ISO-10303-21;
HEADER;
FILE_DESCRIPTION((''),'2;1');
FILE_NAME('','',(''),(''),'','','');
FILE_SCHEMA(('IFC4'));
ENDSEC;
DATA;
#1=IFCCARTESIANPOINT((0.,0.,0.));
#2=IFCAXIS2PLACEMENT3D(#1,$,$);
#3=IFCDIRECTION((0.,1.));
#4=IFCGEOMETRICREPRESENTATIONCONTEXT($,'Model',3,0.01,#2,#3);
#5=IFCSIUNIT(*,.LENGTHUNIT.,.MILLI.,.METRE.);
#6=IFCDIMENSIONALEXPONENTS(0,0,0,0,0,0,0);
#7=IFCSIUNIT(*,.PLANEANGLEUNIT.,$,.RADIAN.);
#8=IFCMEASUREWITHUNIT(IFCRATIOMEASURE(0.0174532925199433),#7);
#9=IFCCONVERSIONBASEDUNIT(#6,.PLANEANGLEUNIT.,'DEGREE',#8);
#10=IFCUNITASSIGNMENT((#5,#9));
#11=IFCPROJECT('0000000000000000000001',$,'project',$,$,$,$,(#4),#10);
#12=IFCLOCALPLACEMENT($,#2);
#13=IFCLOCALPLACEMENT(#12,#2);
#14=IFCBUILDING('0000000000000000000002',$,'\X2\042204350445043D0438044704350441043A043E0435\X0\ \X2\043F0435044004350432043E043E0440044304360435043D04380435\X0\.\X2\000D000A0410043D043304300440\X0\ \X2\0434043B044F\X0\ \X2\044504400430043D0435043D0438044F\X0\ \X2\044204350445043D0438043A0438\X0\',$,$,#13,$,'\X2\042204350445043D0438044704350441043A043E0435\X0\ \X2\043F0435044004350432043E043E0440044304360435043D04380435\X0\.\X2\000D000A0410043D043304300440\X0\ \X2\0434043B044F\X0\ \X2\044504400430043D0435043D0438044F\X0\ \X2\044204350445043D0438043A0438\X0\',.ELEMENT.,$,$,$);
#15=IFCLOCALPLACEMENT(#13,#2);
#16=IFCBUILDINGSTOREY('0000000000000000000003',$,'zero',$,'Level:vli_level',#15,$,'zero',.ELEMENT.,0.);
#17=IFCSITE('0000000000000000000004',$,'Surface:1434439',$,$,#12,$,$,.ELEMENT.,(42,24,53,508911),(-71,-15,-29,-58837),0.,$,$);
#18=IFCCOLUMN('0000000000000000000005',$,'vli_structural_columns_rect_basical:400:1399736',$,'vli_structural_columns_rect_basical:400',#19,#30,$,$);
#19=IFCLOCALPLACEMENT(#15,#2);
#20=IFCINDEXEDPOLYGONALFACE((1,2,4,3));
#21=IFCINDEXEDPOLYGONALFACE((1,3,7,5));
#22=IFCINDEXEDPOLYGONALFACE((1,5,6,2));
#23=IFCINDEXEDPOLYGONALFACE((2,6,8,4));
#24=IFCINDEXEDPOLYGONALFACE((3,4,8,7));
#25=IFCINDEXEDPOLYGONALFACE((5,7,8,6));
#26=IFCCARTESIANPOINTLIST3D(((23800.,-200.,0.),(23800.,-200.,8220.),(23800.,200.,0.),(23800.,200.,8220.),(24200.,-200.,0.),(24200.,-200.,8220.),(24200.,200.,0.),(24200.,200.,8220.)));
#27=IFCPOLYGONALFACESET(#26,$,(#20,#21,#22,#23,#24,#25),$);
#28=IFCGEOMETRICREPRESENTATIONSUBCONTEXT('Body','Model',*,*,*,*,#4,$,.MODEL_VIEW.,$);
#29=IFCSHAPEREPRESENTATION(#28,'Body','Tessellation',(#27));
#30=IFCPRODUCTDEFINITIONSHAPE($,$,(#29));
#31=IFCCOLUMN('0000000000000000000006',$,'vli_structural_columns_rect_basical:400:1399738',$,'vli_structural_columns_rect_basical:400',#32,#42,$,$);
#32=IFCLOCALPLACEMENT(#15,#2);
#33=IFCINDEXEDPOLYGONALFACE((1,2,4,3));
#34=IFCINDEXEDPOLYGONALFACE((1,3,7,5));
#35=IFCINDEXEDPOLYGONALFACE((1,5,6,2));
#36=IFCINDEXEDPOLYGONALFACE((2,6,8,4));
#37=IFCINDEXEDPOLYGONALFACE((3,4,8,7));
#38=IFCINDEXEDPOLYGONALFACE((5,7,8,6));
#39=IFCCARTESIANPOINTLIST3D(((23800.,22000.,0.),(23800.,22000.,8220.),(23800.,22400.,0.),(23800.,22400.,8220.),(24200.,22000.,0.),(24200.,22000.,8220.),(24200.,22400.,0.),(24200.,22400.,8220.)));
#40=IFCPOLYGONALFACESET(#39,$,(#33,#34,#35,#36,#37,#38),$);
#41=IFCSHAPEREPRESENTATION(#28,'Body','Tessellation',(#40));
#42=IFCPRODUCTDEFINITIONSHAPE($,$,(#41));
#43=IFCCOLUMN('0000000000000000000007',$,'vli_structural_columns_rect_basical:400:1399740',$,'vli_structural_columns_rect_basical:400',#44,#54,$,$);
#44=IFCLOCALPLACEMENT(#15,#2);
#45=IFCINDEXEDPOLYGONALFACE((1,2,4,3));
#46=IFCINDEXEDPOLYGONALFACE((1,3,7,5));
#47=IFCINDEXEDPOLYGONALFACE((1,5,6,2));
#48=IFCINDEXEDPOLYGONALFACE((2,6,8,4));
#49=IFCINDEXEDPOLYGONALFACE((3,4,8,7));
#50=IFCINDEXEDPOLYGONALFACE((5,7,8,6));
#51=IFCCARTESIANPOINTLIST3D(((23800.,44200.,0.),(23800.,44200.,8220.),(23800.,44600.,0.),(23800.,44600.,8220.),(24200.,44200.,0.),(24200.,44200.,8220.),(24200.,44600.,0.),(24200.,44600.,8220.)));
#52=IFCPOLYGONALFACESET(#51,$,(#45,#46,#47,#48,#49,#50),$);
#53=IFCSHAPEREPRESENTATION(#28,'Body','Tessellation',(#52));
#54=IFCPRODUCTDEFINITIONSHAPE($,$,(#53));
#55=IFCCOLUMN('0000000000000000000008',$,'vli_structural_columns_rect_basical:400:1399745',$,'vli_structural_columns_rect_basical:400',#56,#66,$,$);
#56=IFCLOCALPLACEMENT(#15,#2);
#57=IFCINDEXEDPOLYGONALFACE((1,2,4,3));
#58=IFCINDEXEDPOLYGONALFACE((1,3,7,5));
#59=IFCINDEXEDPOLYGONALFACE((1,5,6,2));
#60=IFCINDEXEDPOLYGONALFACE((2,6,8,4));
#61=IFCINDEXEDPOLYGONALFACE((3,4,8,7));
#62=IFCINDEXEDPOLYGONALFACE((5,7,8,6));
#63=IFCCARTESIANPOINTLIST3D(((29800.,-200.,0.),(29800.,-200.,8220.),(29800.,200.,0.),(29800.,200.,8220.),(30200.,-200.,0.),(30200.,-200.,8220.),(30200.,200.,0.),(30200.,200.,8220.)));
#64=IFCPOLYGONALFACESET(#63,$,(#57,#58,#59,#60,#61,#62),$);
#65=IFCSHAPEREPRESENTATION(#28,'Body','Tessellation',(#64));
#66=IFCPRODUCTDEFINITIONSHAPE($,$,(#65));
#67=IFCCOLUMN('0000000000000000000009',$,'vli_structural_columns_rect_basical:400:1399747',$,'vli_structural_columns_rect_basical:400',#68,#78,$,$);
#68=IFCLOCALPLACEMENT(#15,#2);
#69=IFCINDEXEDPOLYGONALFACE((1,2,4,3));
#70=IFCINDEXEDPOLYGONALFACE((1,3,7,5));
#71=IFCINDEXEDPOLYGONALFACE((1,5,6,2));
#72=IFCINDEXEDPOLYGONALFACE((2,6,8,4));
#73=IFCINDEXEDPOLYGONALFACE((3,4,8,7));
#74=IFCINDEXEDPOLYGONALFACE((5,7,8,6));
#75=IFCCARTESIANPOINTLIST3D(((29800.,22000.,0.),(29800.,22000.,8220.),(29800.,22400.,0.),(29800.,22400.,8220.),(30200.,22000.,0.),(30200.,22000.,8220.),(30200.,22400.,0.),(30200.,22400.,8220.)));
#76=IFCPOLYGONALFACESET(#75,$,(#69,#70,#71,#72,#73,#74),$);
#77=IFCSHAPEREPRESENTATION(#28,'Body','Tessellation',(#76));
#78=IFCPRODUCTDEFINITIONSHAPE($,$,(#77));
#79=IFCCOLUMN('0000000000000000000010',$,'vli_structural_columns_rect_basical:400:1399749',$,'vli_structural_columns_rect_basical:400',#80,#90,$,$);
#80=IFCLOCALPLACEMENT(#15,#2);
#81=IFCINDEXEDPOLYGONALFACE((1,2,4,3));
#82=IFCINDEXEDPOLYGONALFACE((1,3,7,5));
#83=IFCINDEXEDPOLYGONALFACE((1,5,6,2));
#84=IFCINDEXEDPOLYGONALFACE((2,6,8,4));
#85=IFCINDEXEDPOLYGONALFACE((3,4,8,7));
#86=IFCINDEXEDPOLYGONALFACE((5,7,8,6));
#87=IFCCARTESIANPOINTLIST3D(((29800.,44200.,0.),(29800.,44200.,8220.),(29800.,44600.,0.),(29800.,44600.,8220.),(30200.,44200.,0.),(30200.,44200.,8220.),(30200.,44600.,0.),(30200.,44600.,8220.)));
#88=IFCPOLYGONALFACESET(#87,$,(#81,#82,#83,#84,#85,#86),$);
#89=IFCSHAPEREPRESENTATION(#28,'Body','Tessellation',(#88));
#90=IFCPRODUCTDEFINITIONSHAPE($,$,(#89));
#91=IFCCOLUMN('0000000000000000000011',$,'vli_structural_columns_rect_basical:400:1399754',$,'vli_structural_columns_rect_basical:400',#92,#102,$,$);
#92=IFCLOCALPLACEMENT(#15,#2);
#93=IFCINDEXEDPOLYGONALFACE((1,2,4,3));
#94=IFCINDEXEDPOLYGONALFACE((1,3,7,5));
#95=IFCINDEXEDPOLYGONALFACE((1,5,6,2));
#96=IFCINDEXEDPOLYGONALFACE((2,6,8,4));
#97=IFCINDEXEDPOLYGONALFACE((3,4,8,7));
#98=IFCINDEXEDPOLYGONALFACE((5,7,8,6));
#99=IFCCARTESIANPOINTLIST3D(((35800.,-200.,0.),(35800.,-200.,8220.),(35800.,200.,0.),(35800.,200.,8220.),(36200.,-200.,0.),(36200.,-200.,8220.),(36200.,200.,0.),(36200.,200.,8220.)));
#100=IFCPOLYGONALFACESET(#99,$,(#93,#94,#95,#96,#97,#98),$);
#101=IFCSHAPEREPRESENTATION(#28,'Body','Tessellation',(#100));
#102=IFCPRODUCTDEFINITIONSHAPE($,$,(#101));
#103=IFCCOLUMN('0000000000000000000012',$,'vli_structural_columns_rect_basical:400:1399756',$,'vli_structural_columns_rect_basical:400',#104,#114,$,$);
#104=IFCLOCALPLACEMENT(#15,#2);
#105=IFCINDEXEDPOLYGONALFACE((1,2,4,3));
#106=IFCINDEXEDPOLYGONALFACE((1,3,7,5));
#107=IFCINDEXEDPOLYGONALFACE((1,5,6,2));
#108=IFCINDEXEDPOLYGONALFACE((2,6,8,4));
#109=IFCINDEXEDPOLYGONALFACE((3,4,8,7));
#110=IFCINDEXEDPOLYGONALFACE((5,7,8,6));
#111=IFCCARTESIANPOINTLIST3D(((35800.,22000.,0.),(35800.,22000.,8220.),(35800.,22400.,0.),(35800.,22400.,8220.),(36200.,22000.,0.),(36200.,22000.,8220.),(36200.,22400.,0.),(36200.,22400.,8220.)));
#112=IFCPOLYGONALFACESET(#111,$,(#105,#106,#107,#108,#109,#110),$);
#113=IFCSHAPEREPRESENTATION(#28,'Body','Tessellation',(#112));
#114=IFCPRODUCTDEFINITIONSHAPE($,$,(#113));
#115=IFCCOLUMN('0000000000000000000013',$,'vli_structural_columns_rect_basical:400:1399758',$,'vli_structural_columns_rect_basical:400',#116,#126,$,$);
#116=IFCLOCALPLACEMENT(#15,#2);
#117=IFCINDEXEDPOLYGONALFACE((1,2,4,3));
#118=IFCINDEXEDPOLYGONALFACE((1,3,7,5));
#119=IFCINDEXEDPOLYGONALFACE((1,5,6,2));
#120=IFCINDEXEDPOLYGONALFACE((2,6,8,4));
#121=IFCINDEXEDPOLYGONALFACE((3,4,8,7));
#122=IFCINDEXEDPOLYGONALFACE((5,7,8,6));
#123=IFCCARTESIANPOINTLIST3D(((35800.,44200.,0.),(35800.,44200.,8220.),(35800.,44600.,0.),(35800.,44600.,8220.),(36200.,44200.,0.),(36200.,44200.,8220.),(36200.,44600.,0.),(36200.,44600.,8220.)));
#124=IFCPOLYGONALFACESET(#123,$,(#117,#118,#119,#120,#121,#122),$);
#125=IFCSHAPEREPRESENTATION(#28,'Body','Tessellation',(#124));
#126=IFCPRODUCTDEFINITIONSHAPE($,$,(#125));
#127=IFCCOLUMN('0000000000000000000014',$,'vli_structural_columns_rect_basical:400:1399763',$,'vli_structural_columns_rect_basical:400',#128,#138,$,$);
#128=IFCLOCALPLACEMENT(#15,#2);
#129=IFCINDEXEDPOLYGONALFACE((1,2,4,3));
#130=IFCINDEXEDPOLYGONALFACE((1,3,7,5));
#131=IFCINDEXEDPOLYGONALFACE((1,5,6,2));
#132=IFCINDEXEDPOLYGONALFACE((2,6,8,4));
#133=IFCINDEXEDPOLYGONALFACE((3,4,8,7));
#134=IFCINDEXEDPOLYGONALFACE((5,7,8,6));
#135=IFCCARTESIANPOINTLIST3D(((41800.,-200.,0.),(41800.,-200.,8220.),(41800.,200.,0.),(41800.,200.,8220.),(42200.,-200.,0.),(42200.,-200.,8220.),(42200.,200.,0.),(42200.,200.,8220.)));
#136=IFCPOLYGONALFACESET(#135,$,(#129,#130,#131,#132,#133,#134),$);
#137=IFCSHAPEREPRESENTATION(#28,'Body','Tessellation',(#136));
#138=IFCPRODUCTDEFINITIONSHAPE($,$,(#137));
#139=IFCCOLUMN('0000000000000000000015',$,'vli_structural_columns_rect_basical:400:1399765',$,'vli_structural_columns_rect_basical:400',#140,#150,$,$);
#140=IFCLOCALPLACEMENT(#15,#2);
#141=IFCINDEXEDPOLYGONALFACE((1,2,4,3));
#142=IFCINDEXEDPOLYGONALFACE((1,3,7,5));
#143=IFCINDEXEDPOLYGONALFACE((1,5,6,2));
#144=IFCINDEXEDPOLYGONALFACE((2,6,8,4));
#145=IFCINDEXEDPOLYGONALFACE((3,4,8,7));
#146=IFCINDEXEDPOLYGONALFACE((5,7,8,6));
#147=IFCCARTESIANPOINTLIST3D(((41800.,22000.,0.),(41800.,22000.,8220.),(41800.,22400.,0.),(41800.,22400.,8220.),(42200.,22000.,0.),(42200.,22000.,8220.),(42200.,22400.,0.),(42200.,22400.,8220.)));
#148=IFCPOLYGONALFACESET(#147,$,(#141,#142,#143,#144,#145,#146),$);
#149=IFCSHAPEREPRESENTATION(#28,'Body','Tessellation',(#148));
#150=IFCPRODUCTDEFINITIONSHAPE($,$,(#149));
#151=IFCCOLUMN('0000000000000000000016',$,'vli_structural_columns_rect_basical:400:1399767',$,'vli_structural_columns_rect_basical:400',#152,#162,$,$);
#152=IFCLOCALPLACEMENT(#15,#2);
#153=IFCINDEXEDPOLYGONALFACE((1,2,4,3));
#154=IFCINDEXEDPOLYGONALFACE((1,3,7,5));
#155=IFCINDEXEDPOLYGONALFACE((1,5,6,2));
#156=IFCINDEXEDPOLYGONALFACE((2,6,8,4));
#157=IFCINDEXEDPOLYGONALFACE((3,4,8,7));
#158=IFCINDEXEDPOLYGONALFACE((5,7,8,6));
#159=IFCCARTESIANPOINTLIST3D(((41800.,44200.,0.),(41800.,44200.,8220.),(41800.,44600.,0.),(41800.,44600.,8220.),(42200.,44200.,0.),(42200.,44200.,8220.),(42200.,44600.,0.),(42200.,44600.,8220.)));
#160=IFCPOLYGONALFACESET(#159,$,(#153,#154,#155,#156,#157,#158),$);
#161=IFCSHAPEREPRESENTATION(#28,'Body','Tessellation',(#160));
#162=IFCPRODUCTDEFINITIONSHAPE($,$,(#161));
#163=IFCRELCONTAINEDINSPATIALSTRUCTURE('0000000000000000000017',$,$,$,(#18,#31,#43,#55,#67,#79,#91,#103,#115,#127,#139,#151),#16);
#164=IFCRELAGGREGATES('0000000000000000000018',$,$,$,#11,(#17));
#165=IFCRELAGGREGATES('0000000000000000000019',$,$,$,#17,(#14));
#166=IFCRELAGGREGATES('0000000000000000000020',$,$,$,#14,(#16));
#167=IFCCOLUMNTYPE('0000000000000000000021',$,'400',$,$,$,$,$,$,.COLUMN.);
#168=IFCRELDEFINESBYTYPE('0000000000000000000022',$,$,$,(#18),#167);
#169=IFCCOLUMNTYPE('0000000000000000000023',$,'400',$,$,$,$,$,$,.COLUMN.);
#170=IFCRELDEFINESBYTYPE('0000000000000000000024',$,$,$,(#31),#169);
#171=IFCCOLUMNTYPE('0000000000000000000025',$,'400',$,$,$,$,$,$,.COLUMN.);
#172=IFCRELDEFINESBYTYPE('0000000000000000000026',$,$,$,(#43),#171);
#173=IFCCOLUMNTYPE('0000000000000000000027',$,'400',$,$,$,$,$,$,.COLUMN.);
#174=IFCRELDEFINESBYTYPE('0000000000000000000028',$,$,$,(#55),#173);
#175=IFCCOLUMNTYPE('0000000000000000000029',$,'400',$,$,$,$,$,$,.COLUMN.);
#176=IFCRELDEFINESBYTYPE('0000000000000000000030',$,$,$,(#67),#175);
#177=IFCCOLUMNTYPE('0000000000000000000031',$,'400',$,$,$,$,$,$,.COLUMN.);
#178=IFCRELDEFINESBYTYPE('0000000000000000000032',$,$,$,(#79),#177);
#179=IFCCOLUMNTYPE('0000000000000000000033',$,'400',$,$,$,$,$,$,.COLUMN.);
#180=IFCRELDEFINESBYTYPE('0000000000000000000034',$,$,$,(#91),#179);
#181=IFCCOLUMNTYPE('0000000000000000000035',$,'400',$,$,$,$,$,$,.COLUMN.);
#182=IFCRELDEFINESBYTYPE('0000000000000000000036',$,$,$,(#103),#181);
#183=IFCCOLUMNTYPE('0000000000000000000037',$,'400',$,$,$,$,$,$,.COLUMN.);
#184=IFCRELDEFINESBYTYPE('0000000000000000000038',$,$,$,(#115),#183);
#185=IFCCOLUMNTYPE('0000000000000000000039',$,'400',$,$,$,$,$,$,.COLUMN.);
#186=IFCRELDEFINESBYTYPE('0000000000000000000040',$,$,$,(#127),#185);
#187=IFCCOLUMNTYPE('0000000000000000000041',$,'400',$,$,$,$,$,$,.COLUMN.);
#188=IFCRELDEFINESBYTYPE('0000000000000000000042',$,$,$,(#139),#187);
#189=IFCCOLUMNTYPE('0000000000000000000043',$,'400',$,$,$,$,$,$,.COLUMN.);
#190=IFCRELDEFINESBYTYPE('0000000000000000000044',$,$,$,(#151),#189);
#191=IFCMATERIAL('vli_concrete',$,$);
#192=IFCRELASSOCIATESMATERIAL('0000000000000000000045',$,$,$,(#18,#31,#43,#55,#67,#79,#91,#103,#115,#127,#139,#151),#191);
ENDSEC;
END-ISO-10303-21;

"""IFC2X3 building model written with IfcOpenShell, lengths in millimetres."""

from ifc_helpers import new_model, entity, si_unit, converted_unit, direction, frame, frame_2d, origin, origin_2d_with_axis, place, context, subcontext, project, spatial, rectangle, extrude, source, transform, mapped, material, type_object, type_shapes, element, save


model = new_model("IFC2X3")

# Units and contexts
model_context = context("Model", 3, precision=0.01, world=origin(), true_north=direction((0.0, 1.0)))
body_context = subcontext(model_context, "Body", "Model", "MODEL_VIEW")
ifc_project = project(units=[si_unit("LENGTHUNIT", "METRE", prefix="MILLI"), converted_unit("PLANEANGLEUNIT", "DEGREE", entity("IfcRatioMeasure", 0.0174532925199433), si_unit("PLANEANGLEUNIT", "RADIAN"), dimensions=[0, 0, 0, 0, 0, 0, 0])], contexts=[model_context])

# Site, building, storey
site_placement = place(None, origin())
site = spatial("IfcSite", under=ifc_project, at=site_placement, Name="Surface:1434439", CompositionType="ELEMENT", RefLatitude=(42, 24, 53, 508911), RefLongitude=(-71, -15, -29, -58837), RefElevation=0.0)
building_placement = place(site_placement, origin())
building = spatial("IfcBuilding", under=site, at=building_placement, Name="Техническое перевооружение.\r\nАнгар для хранения техники", LongName="Техническое перевооружение.\r\nАнгар для хранения техники", CompositionType="ELEMENT")
storey_placement = place(building_placement, origin())
storey = spatial("IfcBuildingStorey", under=building, at=storey_placement, Name="zero", ObjectType="Level:vli_level", LongName="zero", CompositionType="ELEMENT", Elevation=0.0)

# Columns
ifc_material_1 = material(Name="vli_concrete")
column_type_1 = type_object("IfcColumnType", Name="400", PredefinedType="COLUMN")
shared_shape_1 = source(origin(), body_context, "Body", "SweptSolid", [
    extrude(rectangle(XDim=400.0, YDim=400.0, at=frame_2d((0.0, 0.0), x_axis=(1.0, 0.0))), frame((24000.0, 0.0, 0.0), z_axis=(0.0, 0.0, 1.0), x_axis=(0.0, -1.0, 0.0)), (0.0, 0.0, 1.0), 8220.0),
])
type_shapes(column_type_1, [shared_shape_1])
column_1_placement = place(storey_placement, origin())
element("IfcColumn", 1, at=column_1_placement, inside=storey, type_object=column_type_1, material=ifc_material_1, Name="vli_structural_columns_rect_basical:400:1399736", ObjectType="vli_structural_columns_rect_basical:400", context=body_context, shape_type="MappedRepresentation", body=[
    mapped(shared_shape_1, transform((0.0, 0.0, 0.0), scale=1.0)),
])
column_type_2 = type_object("IfcColumnType", Name="400", PredefinedType="COLUMN")
shared_shape_2 = source(origin(), body_context, "Body", "SweptSolid", [
    extrude(rectangle(XDim=400.0, YDim=400.0, at=frame_2d((0.0, 0.0), x_axis=(1.0, 0.0))), frame((24000.0, 22200.0, 0.0), z_axis=(0.0, 0.0, 1.0), x_axis=(0.0, -1.0, 0.0)), (0.0, 0.0, 1.0), 8220.0),
])
type_shapes(column_type_2, [shared_shape_2])
column_2_placement = place(storey_placement, origin())
element("IfcColumn", 2, at=column_2_placement, inside=storey, type_object=column_type_2, material=ifc_material_1, Name="vli_structural_columns_rect_basical:400:1399738", ObjectType="vli_structural_columns_rect_basical:400", context=body_context, shape_type="MappedRepresentation", body=[
    mapped(shared_shape_2, transform((0.0, 0.0, 0.0), scale=1.0)),
])
column_type_3 = type_object("IfcColumnType", Name="400", PredefinedType="COLUMN")
shared_shape_3 = source(origin(), body_context, "Body", "SweptSolid", [
    extrude(rectangle(XDim=400.0, YDim=400.0, at=frame_2d((0.0, 0.0), x_axis=(1.0, 0.0))), frame((24000.0, 44400.0, 0.0), z_axis=(0.0, 0.0, 1.0), x_axis=(0.0, -1.0, 0.0)), (0.0, 0.0, 1.0), 8220.0),
])
type_shapes(column_type_3, [shared_shape_3])
column_3_placement = place(storey_placement, origin())
element("IfcColumn", 3, at=column_3_placement, inside=storey, type_object=column_type_3, material=ifc_material_1, Name="vli_structural_columns_rect_basical:400:1399740", ObjectType="vli_structural_columns_rect_basical:400", context=body_context, shape_type="MappedRepresentation", body=[
    mapped(shared_shape_3, transform((0.0, 0.0, 0.0), scale=1.0)),
])
column_type_4 = type_object("IfcColumnType", Name="400", PredefinedType="COLUMN")
shared_shape_4 = source(origin(), body_context, "Body", "SweptSolid", [
    extrude(rectangle(XDim=400.0, YDim=400.0, at=frame_2d((0.0, 0.0), x_axis=(1.0, 0.0))), frame((30000.0, 0.0, 0.0), z_axis=(0.0, 0.0, 1.0), x_axis=(0.0, -1.0, 0.0)), (0.0, 0.0, 1.0), 8220.0),
])
type_shapes(column_type_4, [shared_shape_4])
column_4_placement = place(storey_placement, origin())
element("IfcColumn", 4, at=column_4_placement, inside=storey, type_object=column_type_4, material=ifc_material_1, Name="vli_structural_columns_rect_basical:400:1399745", ObjectType="vli_structural_columns_rect_basical:400", context=body_context, shape_type="MappedRepresentation", body=[
    mapped(shared_shape_4, transform((0.0, 0.0, 0.0), scale=1.0)),
])
column_type_5 = type_object("IfcColumnType", Name="400", PredefinedType="COLUMN")
shared_shape_5 = source(origin(), body_context, "Body", "SweptSolid", [
    extrude(rectangle(XDim=400.0, YDim=400.0, at=frame_2d((0.0, 0.0), x_axis=(1.0, 0.0))), frame((30000.0, 22200.0, 0.0), z_axis=(0.0, 0.0, 1.0), x_axis=(0.0, -1.0, 0.0)), (0.0, 0.0, 1.0), 8220.0),
])
type_shapes(column_type_5, [shared_shape_5])
column_5_placement = place(storey_placement, origin())
element("IfcColumn", 5, at=column_5_placement, inside=storey, type_object=column_type_5, material=ifc_material_1, Name="vli_structural_columns_rect_basical:400:1399747", ObjectType="vli_structural_columns_rect_basical:400", context=body_context, shape_type="MappedRepresentation", body=[
    mapped(shared_shape_5, transform((0.0, 0.0, 0.0), scale=1.0)),
])
column_type_6 = type_object("IfcColumnType", Name="400", PredefinedType="COLUMN")
shared_shape_6 = source(origin(), body_context, "Body", "SweptSolid", [
    extrude(rectangle(XDim=400.0, YDim=400.0, at=frame_2d((0.0, 0.0), x_axis=(1.0, 0.0))), frame((30000.0, 44400.0, 0.0), z_axis=(0.0, 0.0, 1.0), x_axis=(0.0, -1.0, 0.0)), (0.0, 0.0, 1.0), 8220.0),
])
type_shapes(column_type_6, [shared_shape_6])
column_6_placement = place(storey_placement, origin())
element("IfcColumn", 6, at=column_6_placement, inside=storey, type_object=column_type_6, material=ifc_material_1, Name="vli_structural_columns_rect_basical:400:1399749", ObjectType="vli_structural_columns_rect_basical:400", context=body_context, shape_type="MappedRepresentation", body=[
    mapped(shared_shape_6, transform((0.0, 0.0, 0.0), scale=1.0)),
])
column_type_7 = type_object("IfcColumnType", Name="400", PredefinedType="COLUMN")
shared_shape_7 = source(origin(), body_context, "Body", "SweptSolid", [
    extrude(rectangle(XDim=400.0, YDim=400.0, at=frame_2d((0.0, 0.0), x_axis=(1.0, 0.0))), frame((36000.0, 0.0, 0.0), z_axis=(0.0, 0.0, 1.0), x_axis=(0.0, -1.0, 0.0)), (0.0, 0.0, 1.0), 8220.0),
])
type_shapes(column_type_7, [shared_shape_7])
column_7_placement = place(storey_placement, origin())
element("IfcColumn", 7, at=column_7_placement, inside=storey, type_object=column_type_7, material=ifc_material_1, Name="vli_structural_columns_rect_basical:400:1399754", ObjectType="vli_structural_columns_rect_basical:400", context=body_context, shape_type="MappedRepresentation", body=[
    mapped(shared_shape_7, transform((0.0, 0.0, 0.0), scale=1.0)),
])
column_type_8 = type_object("IfcColumnType", Name="400", PredefinedType="COLUMN")
shared_shape_8 = source(origin(), body_context, "Body", "SweptSolid", [
    extrude(rectangle(XDim=400.0, YDim=400.0, at=frame_2d((0.0, 0.0), x_axis=(1.0, 0.0))), frame((36000.0, 22200.0, 0.0), z_axis=(0.0, 0.0, 1.0), x_axis=(0.0, -1.0, 0.0)), (0.0, 0.0, 1.0), 8220.0),
])
type_shapes(column_type_8, [shared_shape_8])
column_8_placement = place(storey_placement, origin())
element("IfcColumn", 8, at=column_8_placement, inside=storey, type_object=column_type_8, material=ifc_material_1, Name="vli_structural_columns_rect_basical:400:1399756", ObjectType="vli_structural_columns_rect_basical:400", context=body_context, shape_type="MappedRepresentation", body=[
    mapped(shared_shape_8, transform((0.0, 0.0, 0.0), scale=1.0)),
])
column_type_9 = type_object("IfcColumnType", Name="400", PredefinedType="COLUMN")
shared_shape_9 = source(origin(), body_context, "Body", "SweptSolid", [
    extrude(rectangle(XDim=400.0, YDim=400.0, at=frame_2d((0.0, 0.0), x_axis=(1.0, 0.0))), frame((36000.0, 44400.0, 0.0), z_axis=(0.0, 0.0, 1.0), x_axis=(0.0, -1.0, 0.0)), (0.0, 0.0, 1.0), 8220.0),
])
type_shapes(column_type_9, [shared_shape_9])
column_9_placement = place(storey_placement, origin())
element("IfcColumn", 9, at=column_9_placement, inside=storey, type_object=column_type_9, material=ifc_material_1, Name="vli_structural_columns_rect_basical:400:1399758", ObjectType="vli_structural_columns_rect_basical:400", context=body_context, shape_type="MappedRepresentation", body=[
    mapped(shared_shape_9, transform((0.0, 0.0, 0.0), scale=1.0)),
])
column_type_10 = type_object("IfcColumnType", Name="400", PredefinedType="COLUMN")
shared_shape_10 = source(origin(), body_context, "Body", "SweptSolid", [
    extrude(rectangle(XDim=400.0, YDim=400.0, at=origin_2d_with_axis()), frame((42000.0, 0.0, 0.0), z_axis=(0.0, 0.0, 1.0), x_axis=(0.0, -1.0, 0.0)), (0.0, 0.0, 1.0), 8220.0),
])
type_shapes(column_type_10, [shared_shape_10])
column_10_placement = place(storey_placement, origin())
element("IfcColumn", 10, at=column_10_placement, inside=storey, type_object=column_type_10, material=ifc_material_1, Name="vli_structural_columns_rect_basical:400:1399763", ObjectType="vli_structural_columns_rect_basical:400", context=body_context, shape_type="MappedRepresentation", body=[
    mapped(shared_shape_10, transform((0.0, 0.0, 0.0), scale=1.0)),
])
column_type_11 = type_object("IfcColumnType", Name="400", PredefinedType="COLUMN")
shared_shape_11 = source(origin(), body_context, "Body", "SweptSolid", [
    extrude(rectangle(XDim=400.0, YDim=400.0, at=frame_2d((0.0, 0.0), x_axis=(1.0, 0.0))), frame((42000.0, 22200.0, 0.0), z_axis=(0.0, 0.0, 1.0), x_axis=(0.0, -1.0, 0.0)), (0.0, 0.0, 1.0), 8220.0),
])
type_shapes(column_type_11, [shared_shape_11])
column_11_placement = place(storey_placement, origin())
element("IfcColumn", 11, at=column_11_placement, inside=storey, type_object=column_type_11, material=ifc_material_1, Name="vli_structural_columns_rect_basical:400:1399765", ObjectType="vli_structural_columns_rect_basical:400", context=body_context, shape_type="MappedRepresentation", body=[
    mapped(shared_shape_11, transform((0.0, 0.0, 0.0), scale=1.0)),
])
column_type_12 = type_object("IfcColumnType", Name="400", PredefinedType="COLUMN")
shared_shape_12 = source(origin(), body_context, "Body", "SweptSolid", [
    extrude(rectangle(XDim=400.0, YDim=400.0, at=origin_2d_with_axis()), frame((42000.0, 44400.0, 0.0), z_axis=(0.0, 0.0, 1.0), x_axis=(0.0, -1.0, 0.0)), (0.0, 0.0, 1.0), 8220.0),
])
type_shapes(column_type_12, [shared_shape_12])
column_12_placement = place(storey_placement, origin())
element("IfcColumn", 12, at=column_12_placement, inside=storey, type_object=column_type_12, material=ifc_material_1, Name="vli_structural_columns_rect_basical:400:1399767", ObjectType="vli_structural_columns_rect_basical:400", context=body_context, shape_type="MappedRepresentation", body=[
    mapped(shared_shape_12, transform((0.0, 0.0, 0.0), scale=1.0)),
])

save(model, "model.ifc")
